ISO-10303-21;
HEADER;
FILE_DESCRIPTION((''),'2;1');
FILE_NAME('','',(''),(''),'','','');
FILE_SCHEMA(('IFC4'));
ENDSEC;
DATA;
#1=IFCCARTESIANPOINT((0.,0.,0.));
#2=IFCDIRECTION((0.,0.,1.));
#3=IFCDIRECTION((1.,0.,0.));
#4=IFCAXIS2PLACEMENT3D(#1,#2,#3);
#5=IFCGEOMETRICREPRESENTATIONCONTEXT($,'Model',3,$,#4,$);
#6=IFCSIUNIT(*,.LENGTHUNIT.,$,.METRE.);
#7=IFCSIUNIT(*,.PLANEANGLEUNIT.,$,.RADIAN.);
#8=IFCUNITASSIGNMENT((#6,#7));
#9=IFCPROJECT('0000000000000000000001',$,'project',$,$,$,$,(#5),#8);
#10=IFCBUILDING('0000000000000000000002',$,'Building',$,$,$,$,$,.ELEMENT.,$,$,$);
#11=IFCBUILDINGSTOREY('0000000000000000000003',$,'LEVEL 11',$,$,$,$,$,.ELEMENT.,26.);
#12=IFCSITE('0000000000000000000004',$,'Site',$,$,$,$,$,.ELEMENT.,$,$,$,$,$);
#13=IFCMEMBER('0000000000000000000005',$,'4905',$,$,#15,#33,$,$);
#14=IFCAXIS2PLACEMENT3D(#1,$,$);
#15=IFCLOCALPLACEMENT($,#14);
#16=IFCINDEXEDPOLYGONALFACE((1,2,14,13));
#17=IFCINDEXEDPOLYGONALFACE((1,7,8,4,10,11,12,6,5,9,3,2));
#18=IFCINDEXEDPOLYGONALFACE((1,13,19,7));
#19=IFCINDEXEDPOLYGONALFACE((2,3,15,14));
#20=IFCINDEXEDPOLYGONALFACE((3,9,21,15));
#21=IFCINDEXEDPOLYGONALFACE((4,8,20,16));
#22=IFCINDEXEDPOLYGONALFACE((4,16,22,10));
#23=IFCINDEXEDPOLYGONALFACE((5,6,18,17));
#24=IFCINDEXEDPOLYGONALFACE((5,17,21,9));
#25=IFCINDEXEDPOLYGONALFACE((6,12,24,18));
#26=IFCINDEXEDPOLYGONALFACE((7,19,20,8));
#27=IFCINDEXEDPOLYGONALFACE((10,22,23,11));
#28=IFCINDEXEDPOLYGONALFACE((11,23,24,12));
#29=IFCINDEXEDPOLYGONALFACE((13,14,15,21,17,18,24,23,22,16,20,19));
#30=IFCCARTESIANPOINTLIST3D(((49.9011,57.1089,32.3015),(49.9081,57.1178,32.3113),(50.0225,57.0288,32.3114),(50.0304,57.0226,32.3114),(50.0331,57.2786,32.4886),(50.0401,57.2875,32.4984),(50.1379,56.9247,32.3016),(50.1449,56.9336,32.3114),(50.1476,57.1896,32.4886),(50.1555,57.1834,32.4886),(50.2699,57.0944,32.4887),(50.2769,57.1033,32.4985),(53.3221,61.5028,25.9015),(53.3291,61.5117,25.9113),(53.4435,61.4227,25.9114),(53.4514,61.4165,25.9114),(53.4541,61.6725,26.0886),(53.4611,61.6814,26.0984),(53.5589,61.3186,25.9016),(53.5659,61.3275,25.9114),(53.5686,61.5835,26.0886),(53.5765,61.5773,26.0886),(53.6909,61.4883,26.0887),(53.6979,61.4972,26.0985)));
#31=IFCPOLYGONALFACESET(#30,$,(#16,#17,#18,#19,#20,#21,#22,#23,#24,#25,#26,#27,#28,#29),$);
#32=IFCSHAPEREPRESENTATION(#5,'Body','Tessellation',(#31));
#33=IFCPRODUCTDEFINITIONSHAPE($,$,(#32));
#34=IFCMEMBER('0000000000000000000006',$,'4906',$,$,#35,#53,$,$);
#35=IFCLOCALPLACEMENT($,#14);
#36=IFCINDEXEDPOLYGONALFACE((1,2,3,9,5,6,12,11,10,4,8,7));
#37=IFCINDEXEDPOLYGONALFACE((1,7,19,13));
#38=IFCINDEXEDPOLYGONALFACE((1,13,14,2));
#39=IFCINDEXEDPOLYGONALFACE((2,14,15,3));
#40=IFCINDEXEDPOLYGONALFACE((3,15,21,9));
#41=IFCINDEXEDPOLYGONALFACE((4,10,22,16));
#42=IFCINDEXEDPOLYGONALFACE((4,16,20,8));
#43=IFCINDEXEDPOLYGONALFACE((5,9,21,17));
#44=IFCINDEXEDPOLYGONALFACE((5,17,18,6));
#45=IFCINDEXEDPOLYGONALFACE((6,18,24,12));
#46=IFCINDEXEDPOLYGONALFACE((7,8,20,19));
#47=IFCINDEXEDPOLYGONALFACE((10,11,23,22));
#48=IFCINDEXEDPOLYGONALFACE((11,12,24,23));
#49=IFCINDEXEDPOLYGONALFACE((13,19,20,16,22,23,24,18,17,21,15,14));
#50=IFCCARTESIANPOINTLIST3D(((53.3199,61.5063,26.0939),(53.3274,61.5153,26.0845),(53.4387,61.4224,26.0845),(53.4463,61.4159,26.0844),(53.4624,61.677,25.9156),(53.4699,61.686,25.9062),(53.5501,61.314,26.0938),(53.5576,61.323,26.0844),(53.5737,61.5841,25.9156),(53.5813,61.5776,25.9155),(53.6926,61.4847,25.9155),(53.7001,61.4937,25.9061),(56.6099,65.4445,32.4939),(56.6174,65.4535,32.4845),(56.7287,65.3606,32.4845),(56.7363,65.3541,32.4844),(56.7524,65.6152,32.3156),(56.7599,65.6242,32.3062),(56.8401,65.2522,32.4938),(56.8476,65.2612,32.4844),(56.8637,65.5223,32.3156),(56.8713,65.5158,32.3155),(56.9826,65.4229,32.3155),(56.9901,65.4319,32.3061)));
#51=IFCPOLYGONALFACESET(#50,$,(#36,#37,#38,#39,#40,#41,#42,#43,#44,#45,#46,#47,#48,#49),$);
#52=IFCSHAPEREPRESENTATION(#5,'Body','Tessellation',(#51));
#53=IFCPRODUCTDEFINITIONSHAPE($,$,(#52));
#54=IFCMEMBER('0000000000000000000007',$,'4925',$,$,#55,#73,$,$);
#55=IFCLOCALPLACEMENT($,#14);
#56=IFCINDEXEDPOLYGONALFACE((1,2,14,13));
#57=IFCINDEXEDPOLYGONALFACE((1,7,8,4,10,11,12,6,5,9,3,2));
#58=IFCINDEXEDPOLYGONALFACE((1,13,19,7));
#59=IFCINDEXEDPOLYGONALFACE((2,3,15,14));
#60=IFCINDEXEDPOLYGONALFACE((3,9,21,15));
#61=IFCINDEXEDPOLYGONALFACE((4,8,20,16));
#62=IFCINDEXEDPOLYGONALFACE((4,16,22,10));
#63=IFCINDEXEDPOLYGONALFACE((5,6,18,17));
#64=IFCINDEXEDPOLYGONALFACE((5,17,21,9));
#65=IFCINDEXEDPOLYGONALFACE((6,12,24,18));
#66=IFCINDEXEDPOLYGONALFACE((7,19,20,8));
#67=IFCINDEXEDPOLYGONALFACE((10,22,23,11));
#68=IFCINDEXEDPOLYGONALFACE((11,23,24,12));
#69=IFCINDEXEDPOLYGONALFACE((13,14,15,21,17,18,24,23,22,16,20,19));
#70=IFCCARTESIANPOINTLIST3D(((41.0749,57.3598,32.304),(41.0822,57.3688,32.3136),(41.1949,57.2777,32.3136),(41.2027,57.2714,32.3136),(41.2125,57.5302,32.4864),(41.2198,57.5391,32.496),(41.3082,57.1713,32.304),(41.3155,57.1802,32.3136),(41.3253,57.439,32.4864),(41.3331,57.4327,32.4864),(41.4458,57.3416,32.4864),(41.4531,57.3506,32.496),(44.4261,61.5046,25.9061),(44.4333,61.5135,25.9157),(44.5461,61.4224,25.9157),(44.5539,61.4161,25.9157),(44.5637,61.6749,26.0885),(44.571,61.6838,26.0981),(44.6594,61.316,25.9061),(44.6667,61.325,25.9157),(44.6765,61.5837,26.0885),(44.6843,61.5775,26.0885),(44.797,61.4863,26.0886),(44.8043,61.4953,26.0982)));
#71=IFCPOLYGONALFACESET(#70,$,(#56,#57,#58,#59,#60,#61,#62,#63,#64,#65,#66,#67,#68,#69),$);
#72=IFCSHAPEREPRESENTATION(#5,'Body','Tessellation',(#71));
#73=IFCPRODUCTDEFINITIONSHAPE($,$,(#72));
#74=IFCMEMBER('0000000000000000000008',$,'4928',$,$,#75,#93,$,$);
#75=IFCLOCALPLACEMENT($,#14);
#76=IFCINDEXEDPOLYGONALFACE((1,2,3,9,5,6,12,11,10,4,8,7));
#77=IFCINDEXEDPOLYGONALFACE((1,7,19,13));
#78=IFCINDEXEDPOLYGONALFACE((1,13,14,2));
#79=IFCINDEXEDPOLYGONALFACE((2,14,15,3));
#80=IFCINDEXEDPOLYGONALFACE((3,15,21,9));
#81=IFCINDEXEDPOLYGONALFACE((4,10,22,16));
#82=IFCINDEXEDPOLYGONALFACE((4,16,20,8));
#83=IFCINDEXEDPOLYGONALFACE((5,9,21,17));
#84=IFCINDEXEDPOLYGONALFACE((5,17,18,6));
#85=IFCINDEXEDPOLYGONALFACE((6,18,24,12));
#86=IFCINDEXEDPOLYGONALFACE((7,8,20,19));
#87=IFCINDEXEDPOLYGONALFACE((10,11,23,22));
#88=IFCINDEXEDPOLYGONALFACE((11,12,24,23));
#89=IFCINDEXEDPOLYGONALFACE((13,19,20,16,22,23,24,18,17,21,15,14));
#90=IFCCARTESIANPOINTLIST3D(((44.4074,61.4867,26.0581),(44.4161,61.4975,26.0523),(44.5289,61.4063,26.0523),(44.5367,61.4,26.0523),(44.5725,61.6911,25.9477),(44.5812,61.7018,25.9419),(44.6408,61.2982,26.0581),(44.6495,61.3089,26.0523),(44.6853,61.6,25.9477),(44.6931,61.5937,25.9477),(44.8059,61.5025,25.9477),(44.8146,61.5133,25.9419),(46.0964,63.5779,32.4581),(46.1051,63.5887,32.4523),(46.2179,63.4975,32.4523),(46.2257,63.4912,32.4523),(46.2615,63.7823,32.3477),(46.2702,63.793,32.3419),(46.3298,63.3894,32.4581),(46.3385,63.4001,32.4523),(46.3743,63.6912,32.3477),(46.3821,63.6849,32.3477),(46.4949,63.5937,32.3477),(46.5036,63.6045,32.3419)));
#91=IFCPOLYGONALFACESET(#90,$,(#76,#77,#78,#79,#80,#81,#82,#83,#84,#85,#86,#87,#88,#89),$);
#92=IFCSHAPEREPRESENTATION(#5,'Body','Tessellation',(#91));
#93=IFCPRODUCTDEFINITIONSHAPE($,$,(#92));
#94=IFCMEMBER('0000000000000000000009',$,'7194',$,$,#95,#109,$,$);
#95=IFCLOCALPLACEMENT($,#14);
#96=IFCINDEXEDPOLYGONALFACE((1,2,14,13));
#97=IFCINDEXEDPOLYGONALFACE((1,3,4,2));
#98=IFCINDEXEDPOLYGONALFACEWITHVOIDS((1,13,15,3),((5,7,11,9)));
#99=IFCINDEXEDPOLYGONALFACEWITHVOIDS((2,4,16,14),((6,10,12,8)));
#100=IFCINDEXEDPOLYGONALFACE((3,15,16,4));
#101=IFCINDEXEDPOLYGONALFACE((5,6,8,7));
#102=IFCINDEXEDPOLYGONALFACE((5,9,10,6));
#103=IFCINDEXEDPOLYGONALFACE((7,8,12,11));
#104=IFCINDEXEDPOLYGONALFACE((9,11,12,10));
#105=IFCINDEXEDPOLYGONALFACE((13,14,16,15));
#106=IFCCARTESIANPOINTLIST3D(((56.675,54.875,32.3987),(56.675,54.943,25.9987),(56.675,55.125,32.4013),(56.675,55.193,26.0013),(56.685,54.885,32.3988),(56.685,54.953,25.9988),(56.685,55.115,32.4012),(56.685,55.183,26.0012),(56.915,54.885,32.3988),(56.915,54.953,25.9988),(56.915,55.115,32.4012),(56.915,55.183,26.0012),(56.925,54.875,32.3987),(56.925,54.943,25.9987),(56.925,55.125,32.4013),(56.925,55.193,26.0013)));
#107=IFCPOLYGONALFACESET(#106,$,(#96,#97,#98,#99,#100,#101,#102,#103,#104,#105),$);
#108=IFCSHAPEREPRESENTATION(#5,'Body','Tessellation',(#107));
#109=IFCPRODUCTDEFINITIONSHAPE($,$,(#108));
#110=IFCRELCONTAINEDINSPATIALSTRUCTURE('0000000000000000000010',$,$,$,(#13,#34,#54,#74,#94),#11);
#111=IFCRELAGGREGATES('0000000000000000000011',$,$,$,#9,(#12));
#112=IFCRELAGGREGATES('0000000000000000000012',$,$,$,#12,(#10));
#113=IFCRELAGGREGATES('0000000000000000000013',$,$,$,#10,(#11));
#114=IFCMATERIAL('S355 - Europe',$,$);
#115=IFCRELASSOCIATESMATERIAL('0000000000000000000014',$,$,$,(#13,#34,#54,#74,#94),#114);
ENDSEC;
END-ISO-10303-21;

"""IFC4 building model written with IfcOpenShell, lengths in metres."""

from ifc_helpers import new_model, si_unit, frame, origin_with_axes, origin_2d_with_axis, place, context, project, spatial, hollow_rectangle, i_section, extrude, material, material_profile, profile_set, profile_usage, element, save


model = new_model("IFC4")

# Units and contexts
model_context = context("Model", 3, world=origin_with_axes())
ifc_project = project(units=[si_unit("LENGTHUNIT", "METRE"), si_unit("PLANEANGLEUNIT", "RADIAN")], contexts=[model_context])

# Site, building, storey
site = spatial("IfcSite", under=ifc_project, Name="Site", CompositionType="ELEMENT")
building = spatial("IfcBuilding", under=site, Name="Building", CompositionType="ELEMENT")
storey = spatial("IfcBuildingStorey", under=building, Name="LEVEL 11", CompositionType="ELEMENT", Elevation=26.0)

# Shared definitions
ifc_material = material(Name="S355 - Europe")

# Members
ifc_material_profile_1 = material_profile(ifc_material, i_section(OverallWidth=0.3, OverallDepth=0.3, WebThickness=0.01, FlangeThickness=0.015, at=origin_2d_with_axis()))
ifc_profile_set_1 = profile_set([ifc_material_profile_1])
ifc_profile_usage_1 = profile_usage(ifc_profile_set_1, cardinal=10)
member_1_placement = place(None, frame((50.089, 57.1061, 32.4), z_axis=(0.403254, 0.517935, -0.754407), x_axis=(-0.789418, 0.613857, 0.0)))
element("IfcMember", 1, at=member_1_placement, inside=storey, material=ifc_profile_usage_1, Name="4905", context=model_context, shape_type="SweptSolid", body=[
    extrude(i_section(OverallWidth=0.3, OverallDepth=0.3, WebThickness=0.01, FlangeThickness=0.015, at=origin_2d_with_axis()), origin_with_axes(), (0.0, 0.0, 1.0), 8.4835),
])
ifc_material_profile_2 = material_profile(ifc_material, i_section(OverallWidth=0.3, OverallDepth=0.3, WebThickness=0.01, FlangeThickness=0.015, at=origin_2d_with_axis()))
ifc_profile_set_2 = profile_set([ifc_material_profile_2])
ifc_profile_usage_2 = profile_usage(ifc_profile_set_2, cardinal=10)
member_2_placement = place(None, frame((53.51, 61.5, 26.0), z_axis=(0.40106, 0.480077, 0.780177), x_axis=(-0.767589, 0.640942, 0.0)))
element("IfcMember", 2, at=member_2_placement, inside=storey, material=ifc_profile_usage_2, Name="4906", context=model_context, shape_type="SweptSolid", body=[
    extrude(i_section(OverallWidth=0.3, OverallDepth=0.3, WebThickness=0.01, FlangeThickness=0.015, at=origin_2d_with_axis()), origin_with_axes(), (0.0, 0.0, 1.0), 8.2033),
])
ifc_material_profile_3 = material_profile(ifc_material, i_section(OverallWidth=0.3, OverallDepth=0.3, WebThickness=0.01, FlangeThickness=0.015, at=origin_2d_with_axis()))
ifc_profile_set_3 = profile_set([ifc_material_profile_3])
ifc_profile_usage_3 = profile_usage(ifc_profile_set_3, cardinal=10)
member_3_placement = place(None, frame((41.264, 57.3552, 32.4), z_axis=(0.402439, 0.497734, -0.768312), x_axis=(-0.777826, 0.62848, 0.0)))
element("IfcMember", 3, at=member_3_placement, inside=storey, material=ifc_profile_usage_3, Name="4925", context=model_context, shape_type="SweptSolid", body=[
    extrude(i_section(OverallWidth=0.3, OverallDepth=0.3, WebThickness=0.01, FlangeThickness=0.015, at=origin_2d_with_axis()), origin_with_axes(), (0.0, 0.0, 1.0), 8.3272),
])
ifc_material_profile_4 = material_profile(ifc_material, i_section(OverallWidth=0.3, OverallDepth=0.3, WebThickness=0.01, FlangeThickness=0.015, at=origin_2d_with_axis()))
ifc_profile_set_4 = profile_set([ifc_material_profile_4])
ifc_profile_usage_4 = profile_usage(ifc_profile_set_4, cardinal=10)
member_4_placement = place(None, frame((44.611, 61.5, 26.0), z_axis=(0.243316, 0.301256, 0.921977), x_axis=(-0.777826, 0.62848, 0.0)))
element("IfcMember", 4, at=member_4_placement, inside=storey, material=ifc_profile_usage_4, Name="4928", context=model_context, shape_type="SweptSolid", body=[
    extrude(i_section(OverallWidth=0.3, OverallDepth=0.3, WebThickness=0.01, FlangeThickness=0.015, at=origin_2d_with_axis()), origin_with_axes(), (0.0, 0.0, 1.0), 6.9416),
])
ifc_material_profile_5 = material_profile(ifc_material, hollow_rectangle(XDim=0.25, YDim=0.25, WallThickness=0.01, at=origin_2d_with_axis()))
ifc_profile_set_5 = profile_set([ifc_material_profile_5])
ifc_profile_usage_5 = profile_usage(ifc_profile_set_5, cardinal=10)
member_5_placement = place(None, frame((56.8, 55.068, 26.0), z_axis=(0.0, -0.010624, 0.999944), x_axis=(1.0, 0.0, 0.0)))
element("IfcMember", 5, at=member_5_placement, inside=storey, material=ifc_profile_usage_5, Name="7194", context=model_context, shape_type="SweptSolid", body=[
    extrude(hollow_rectangle(XDim=0.25, YDim=0.25, WallThickness=0.01, at=origin_2d_with_axis()), origin_with_axes(), (0.0, 0.0, 1.0), 6.4004),
])

save(model, "model.ifc")
